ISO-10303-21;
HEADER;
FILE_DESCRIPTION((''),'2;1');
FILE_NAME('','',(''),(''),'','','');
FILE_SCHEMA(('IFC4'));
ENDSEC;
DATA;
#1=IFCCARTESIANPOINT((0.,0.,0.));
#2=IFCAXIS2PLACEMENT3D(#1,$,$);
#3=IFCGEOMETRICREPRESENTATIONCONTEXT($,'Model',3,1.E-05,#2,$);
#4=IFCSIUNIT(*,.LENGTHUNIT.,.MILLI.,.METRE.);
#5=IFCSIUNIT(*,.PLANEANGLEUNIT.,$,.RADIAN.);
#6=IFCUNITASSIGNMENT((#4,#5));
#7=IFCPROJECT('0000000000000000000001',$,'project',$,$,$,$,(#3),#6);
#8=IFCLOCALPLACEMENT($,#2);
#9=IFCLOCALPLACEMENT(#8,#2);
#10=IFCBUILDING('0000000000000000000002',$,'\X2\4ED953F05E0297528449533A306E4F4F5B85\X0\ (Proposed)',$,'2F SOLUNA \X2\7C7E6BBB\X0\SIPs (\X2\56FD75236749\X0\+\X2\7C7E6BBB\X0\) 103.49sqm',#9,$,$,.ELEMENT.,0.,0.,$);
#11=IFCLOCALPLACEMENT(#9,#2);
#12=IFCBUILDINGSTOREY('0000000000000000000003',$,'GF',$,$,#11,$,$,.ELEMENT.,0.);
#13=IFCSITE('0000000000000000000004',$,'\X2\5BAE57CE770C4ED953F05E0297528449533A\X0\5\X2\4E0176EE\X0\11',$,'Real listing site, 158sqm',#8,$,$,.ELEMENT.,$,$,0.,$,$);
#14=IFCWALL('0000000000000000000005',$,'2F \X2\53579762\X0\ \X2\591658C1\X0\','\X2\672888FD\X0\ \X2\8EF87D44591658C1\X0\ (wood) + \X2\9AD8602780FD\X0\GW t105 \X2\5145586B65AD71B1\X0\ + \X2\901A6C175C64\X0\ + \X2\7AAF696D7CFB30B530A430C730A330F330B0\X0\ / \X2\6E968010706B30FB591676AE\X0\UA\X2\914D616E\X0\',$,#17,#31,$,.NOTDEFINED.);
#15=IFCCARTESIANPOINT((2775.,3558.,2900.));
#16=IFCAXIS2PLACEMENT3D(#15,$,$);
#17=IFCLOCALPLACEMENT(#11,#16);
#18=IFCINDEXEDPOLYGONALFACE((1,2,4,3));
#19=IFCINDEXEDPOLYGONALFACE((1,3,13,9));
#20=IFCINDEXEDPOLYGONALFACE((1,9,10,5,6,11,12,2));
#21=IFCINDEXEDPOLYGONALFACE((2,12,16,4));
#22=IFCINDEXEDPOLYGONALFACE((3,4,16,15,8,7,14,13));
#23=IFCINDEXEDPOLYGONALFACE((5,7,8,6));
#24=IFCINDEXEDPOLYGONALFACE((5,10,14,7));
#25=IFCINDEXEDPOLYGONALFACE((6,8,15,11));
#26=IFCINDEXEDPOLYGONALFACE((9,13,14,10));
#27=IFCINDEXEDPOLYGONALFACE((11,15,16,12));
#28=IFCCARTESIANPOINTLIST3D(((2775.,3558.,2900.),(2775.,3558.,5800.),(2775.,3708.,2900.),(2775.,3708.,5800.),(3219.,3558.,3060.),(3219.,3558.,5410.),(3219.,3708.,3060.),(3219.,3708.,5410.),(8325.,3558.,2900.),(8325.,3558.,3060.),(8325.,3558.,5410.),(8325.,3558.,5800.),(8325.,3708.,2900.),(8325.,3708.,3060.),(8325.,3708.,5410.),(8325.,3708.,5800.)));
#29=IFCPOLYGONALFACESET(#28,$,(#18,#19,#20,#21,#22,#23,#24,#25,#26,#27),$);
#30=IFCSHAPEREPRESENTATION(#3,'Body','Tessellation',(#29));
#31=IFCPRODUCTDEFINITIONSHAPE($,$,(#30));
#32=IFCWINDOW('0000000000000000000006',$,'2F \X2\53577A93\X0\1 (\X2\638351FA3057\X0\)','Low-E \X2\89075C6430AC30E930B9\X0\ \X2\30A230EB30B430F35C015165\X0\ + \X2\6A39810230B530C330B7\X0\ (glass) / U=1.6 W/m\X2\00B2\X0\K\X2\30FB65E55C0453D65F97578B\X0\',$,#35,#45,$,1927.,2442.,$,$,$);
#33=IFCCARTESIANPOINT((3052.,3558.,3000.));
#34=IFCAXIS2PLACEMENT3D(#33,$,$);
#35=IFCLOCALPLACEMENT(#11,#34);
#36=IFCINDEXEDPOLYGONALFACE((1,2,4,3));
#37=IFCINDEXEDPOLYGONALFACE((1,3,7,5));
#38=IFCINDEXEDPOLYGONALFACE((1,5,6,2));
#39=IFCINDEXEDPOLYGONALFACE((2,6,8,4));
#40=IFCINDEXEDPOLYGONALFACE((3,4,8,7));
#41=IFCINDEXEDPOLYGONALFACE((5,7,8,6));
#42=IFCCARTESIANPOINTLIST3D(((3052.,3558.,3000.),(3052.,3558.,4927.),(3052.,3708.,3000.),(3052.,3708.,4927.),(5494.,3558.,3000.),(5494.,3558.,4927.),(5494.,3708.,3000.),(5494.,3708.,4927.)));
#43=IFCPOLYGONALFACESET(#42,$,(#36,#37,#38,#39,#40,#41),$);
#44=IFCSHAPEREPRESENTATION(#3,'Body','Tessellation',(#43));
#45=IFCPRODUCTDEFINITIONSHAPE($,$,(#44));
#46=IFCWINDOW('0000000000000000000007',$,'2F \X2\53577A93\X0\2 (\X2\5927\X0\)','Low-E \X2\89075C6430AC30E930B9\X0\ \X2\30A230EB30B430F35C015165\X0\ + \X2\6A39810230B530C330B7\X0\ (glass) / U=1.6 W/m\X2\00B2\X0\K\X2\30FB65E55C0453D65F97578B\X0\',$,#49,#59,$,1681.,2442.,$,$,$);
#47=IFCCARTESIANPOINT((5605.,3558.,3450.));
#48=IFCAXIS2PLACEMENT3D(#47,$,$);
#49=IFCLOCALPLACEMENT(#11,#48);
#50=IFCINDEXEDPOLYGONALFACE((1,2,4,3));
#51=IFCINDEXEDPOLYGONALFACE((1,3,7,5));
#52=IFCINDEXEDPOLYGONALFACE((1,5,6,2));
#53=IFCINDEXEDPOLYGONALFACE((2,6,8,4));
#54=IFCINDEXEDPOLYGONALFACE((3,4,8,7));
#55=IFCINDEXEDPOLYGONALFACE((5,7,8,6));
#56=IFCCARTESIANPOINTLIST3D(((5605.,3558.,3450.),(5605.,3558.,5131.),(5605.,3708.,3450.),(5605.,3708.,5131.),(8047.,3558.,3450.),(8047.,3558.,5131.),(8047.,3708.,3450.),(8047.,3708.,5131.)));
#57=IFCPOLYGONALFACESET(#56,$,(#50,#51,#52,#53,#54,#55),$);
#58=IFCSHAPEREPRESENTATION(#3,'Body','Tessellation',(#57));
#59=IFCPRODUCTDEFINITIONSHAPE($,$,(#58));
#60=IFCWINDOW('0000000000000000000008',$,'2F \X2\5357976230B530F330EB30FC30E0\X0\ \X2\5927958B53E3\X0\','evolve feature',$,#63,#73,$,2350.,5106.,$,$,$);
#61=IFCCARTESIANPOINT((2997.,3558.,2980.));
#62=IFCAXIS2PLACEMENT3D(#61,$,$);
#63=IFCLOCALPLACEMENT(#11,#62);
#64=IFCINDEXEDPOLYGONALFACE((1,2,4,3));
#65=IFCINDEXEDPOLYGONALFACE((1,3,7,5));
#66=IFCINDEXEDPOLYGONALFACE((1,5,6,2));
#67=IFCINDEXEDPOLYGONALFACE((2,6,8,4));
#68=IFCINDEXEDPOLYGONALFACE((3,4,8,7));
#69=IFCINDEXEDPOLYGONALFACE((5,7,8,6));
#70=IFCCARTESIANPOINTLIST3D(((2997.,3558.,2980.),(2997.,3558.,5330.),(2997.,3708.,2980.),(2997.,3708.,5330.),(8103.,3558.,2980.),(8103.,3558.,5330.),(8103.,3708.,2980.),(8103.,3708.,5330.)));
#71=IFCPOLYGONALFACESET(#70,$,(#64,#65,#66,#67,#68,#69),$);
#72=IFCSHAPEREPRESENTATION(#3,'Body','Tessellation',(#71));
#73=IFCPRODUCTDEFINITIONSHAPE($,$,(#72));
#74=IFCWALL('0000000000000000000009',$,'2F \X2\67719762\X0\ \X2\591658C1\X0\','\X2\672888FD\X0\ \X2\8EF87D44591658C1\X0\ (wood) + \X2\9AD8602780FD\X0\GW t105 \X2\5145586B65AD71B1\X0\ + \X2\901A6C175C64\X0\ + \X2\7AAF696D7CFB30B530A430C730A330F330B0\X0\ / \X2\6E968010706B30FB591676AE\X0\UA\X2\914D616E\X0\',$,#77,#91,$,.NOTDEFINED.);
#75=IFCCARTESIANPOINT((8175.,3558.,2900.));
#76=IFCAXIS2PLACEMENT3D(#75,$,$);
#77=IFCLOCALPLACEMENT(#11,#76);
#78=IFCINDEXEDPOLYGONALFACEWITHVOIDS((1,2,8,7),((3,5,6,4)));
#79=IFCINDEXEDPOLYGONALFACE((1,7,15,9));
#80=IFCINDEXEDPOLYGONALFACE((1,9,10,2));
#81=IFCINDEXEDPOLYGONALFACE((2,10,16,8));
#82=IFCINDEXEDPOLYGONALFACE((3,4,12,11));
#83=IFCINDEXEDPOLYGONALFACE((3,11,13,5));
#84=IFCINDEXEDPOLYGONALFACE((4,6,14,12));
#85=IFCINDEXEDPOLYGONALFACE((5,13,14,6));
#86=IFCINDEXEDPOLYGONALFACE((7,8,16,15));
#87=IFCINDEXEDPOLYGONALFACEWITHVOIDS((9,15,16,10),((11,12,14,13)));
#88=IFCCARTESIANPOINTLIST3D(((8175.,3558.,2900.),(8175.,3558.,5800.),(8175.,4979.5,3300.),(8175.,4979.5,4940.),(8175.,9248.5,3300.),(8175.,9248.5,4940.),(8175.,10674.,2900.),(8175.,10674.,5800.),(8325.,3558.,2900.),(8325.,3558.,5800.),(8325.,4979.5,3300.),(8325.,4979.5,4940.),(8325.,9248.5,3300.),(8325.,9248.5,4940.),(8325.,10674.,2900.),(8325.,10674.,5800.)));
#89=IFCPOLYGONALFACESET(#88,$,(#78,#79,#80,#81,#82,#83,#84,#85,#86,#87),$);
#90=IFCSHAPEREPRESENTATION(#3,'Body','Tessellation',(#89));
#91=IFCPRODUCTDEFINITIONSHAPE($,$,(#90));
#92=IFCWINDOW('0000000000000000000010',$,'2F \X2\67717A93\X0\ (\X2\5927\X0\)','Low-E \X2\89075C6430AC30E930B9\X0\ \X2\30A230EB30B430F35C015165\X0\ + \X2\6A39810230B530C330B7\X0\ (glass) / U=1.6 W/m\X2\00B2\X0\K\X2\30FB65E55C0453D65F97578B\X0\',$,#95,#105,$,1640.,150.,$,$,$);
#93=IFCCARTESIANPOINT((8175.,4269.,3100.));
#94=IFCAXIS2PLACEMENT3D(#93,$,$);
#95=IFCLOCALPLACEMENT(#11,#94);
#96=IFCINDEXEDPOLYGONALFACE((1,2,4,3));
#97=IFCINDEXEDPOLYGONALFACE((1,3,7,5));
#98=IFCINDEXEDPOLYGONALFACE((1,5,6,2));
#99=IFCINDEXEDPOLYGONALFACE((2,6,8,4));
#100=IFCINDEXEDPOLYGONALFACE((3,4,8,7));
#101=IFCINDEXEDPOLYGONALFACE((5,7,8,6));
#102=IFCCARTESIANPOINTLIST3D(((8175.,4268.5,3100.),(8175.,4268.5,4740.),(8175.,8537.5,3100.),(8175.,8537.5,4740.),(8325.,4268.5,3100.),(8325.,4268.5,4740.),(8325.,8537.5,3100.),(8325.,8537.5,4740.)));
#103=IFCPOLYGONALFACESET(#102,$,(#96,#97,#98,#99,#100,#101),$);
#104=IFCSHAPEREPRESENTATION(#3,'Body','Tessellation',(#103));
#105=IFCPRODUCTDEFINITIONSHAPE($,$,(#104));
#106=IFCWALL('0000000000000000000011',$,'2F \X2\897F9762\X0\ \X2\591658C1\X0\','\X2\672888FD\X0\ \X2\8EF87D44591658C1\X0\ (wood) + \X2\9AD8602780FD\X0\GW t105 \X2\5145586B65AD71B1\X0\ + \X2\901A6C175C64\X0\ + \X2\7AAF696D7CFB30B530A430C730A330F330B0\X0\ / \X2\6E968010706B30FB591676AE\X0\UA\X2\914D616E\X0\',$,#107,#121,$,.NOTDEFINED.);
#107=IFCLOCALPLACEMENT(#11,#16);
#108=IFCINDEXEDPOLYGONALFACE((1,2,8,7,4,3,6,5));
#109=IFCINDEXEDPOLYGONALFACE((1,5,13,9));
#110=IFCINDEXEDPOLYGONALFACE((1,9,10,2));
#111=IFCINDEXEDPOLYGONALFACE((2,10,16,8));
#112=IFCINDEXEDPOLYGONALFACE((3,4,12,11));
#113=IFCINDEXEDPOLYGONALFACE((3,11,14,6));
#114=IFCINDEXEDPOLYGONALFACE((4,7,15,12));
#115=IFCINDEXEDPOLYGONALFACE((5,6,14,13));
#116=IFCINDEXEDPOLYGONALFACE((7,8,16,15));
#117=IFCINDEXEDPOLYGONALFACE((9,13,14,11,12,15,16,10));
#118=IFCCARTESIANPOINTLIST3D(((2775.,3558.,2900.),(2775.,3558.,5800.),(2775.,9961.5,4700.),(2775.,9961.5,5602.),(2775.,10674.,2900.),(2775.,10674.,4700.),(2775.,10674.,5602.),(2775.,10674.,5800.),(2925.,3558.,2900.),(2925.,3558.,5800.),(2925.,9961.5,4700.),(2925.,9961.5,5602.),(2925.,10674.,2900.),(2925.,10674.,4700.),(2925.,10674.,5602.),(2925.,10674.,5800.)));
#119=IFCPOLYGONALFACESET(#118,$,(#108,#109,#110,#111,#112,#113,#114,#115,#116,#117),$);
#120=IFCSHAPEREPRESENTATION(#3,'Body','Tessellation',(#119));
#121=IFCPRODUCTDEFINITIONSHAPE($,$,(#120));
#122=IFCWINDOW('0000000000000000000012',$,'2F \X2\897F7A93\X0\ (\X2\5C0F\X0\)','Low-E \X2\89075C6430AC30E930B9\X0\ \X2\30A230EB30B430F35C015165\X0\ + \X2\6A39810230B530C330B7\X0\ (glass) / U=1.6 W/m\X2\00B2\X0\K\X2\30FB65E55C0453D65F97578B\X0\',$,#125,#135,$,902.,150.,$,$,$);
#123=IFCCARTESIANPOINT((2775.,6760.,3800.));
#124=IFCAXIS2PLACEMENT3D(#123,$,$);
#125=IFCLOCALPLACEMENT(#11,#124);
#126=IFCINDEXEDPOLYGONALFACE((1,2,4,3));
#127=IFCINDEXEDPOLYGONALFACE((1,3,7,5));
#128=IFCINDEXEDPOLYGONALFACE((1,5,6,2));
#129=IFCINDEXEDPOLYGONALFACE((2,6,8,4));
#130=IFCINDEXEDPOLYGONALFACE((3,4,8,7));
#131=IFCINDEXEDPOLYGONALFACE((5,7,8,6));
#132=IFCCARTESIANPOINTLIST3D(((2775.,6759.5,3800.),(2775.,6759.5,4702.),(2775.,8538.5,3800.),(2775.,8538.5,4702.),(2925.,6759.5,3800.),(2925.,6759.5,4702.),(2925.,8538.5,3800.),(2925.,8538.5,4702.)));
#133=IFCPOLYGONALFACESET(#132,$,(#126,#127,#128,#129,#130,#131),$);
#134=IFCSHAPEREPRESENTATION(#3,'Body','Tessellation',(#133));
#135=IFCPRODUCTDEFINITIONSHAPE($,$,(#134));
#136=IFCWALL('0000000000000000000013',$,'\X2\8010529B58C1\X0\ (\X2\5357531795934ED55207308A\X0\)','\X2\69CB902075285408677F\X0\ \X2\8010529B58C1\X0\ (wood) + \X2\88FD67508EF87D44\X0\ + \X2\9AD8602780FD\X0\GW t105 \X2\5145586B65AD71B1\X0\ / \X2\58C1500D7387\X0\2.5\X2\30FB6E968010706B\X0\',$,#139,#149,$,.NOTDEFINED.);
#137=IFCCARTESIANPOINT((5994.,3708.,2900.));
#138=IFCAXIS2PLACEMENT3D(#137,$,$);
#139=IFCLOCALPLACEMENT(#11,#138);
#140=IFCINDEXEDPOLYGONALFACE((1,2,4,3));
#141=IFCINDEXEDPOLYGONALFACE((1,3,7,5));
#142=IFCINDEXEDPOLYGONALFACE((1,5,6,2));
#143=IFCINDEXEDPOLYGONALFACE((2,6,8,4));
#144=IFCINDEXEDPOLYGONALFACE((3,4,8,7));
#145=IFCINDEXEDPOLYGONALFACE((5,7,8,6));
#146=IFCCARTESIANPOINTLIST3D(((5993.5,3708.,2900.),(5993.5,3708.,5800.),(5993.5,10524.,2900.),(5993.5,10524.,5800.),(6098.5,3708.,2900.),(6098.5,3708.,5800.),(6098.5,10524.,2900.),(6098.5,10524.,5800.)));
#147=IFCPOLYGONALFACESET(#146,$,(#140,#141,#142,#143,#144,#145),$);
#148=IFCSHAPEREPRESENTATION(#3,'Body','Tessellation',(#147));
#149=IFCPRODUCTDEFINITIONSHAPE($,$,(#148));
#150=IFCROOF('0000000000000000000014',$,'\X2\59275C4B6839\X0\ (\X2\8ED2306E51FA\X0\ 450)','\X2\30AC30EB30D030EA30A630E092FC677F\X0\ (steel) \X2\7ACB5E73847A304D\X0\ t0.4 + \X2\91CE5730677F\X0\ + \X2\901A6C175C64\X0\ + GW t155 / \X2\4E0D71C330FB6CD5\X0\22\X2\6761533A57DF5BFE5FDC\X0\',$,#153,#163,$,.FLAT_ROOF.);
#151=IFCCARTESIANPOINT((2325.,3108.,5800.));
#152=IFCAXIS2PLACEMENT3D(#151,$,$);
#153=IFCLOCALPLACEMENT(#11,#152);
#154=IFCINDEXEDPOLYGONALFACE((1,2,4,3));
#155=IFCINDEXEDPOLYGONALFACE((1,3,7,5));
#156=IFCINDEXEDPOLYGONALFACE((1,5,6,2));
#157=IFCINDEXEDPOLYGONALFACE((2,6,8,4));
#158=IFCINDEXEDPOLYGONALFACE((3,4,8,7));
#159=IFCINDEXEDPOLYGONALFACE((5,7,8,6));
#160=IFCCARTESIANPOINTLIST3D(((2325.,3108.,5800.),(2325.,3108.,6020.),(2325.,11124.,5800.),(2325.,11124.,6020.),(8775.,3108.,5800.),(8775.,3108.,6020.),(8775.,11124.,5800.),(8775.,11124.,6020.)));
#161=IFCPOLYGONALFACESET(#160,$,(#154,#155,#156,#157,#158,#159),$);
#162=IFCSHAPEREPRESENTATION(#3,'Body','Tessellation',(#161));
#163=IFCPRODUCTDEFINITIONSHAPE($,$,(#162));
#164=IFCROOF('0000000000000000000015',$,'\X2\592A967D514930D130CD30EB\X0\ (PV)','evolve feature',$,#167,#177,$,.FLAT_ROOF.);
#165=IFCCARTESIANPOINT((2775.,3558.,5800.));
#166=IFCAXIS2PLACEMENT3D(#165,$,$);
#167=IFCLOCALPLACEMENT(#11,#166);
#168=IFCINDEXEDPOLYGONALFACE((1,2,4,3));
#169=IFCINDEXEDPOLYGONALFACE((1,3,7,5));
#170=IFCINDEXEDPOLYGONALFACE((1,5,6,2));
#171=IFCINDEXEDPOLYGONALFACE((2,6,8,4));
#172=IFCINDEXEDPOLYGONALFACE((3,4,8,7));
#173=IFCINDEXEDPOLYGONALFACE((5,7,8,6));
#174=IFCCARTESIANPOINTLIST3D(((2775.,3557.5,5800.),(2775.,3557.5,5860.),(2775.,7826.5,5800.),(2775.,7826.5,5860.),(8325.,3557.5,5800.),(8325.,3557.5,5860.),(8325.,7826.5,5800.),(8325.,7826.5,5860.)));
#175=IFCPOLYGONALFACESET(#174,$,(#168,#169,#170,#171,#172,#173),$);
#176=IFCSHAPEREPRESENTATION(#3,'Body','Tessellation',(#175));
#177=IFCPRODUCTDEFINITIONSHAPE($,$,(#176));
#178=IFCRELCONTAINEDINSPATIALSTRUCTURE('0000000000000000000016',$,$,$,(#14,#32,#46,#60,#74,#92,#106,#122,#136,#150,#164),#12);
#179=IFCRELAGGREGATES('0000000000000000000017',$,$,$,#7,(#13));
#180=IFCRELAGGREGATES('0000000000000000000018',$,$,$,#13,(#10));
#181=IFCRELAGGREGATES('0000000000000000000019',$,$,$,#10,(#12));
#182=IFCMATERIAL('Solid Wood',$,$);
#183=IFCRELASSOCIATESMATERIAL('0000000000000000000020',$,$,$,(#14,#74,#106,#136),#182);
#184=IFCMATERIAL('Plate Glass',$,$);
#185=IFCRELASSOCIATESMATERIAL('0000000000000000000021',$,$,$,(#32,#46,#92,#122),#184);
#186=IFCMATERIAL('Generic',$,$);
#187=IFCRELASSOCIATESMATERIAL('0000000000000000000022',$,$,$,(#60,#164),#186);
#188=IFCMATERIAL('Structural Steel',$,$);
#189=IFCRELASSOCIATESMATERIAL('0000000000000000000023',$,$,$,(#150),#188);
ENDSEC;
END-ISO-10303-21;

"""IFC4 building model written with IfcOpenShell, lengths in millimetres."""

from ifc_helpers import new_model, si_unit, frame, frame_2d, origin, place, context, project, spatial, rectangle, extrude, material, element, fill, save


model = new_model("IFC4")

# Units and contexts
model_context = context("Model", 3, precision=1e-05, world=origin())
ifc_project = project(units=[si_unit("LENGTHUNIT", "METRE", prefix="MILLI"), si_unit("PLANEANGLEUNIT", "RADIAN")], contexts=[model_context])

# Site, building, storey
site_placement = place(None, origin())
site = spatial("IfcSite", under=ifc_project, at=site_placement, Name="宮城県仙台市青葉区5丁目11", ObjectType="Real listing site, 158sqm", CompositionType="ELEMENT", RefElevation=0.0)
building_placement = place(site_placement, origin())
building = spatial("IfcBuilding", under=site, at=building_placement, Name="仙台市青葉区の住宅 (Proposed)", ObjectType="2F SOLUNA 籾殻SIPs (国産杉+籾殻) 103.49sqm", CompositionType="ELEMENT", ElevationOfRefHeight=0.0, ElevationOfTerrain=0.0)
storey_placement = place(building_placement, origin())
storey = spatial("IfcBuildingStorey", under=building, at=storey_placement, Name="GF", CompositionType="ELEMENT", Elevation=0.0)

# Shared definitions
ifc_material_1 = material(Name="Solid Wood")

# Wall, openings, windows
wall_1_placement = place(storey_placement, frame((2775.0, 3558.0, 2900.0)))
wall_1 = element("IfcWall", 1, at=wall_1_placement, inside=storey, material=ifc_material_1, Name="2F 南面 外壁", Description="木製 軸組外壁 (wood) + 高性能GW t105 充填断熱 + 通気層 + 窯業系サイディング / 準耐火・外皮UA配慮", PredefinedType="NOTDEFINED", context=model_context, shape_type="SweptSolid", body=[
    extrude(rectangle(XDim=5550.0, YDim=150.0, at=frame_2d((2775.0, 75.0))), frame((2775.0, 3558.0, 2900.0)), (0.0, 0.0, 1.0), 2900.0),
])
opening_1_placement = place(storey_placement, frame((3052.0, 3558.0, 3000.0)))
opening_1 = element("IfcOpeningElement", 2, at=opening_1_placement, cuts=wall_1, PredefinedType="NOTDEFINED", context=model_context, shape_type="SweptSolid", body=[
    extrude(rectangle(XDim=2442.0, YDim=150.0, at=frame_2d((1221.0, 75.0))), frame((3052.0, 3558.0, 3000.0)), (0.0, 0.0, 1.0), 1927.0),
])
opening_2_placement = place(storey_placement, frame((5605.0, 3558.0, 3450.0)))
opening_2 = element("IfcOpeningElement", 3, at=opening_2_placement, cuts=wall_1, PredefinedType="NOTDEFINED", context=model_context, shape_type="SweptSolid", body=[
    extrude(rectangle(XDim=2442.0, YDim=150.0, at=frame_2d((1221.0, 75.0))), frame((5605.0, 3558.0, 3450.0)), (0.0, 0.0, 1.0), 1681.0),
])
opening_3_placement = place(storey_placement, frame((2997.0, 3558.0, 2980.0)))
opening_3 = element("IfcOpeningElement", 4, at=opening_3_placement, cuts=wall_1, PredefinedType="NOTDEFINED", context=model_context, shape_type="SweptSolid", body=[
    extrude(rectangle(XDim=5106.0, YDim=150.0, at=frame_2d((2553.0, 75.0))), frame((2997.0, 3558.0, 2980.0)), (0.0, 0.0, 1.0), 2350.0),
])
ifc_material_2 = material(Name="Plate Glass")
window_1_placement = place(storey_placement, frame((3052.0, 3558.0, 3000.0)))
window_1 = element("IfcWindow", 5, at=window_1_placement, inside=storey, material=ifc_material_2, Name="2F 南窓1 (掃出し)", Description="Low-E 複層ガラス アルゴン封入 + 樹脂サッシ (glass) / U=1.6 W/m²K・日射取得型", OverallHeight=1927.0, OverallWidth=2442.0, context=model_context, shape_type="SweptSolid", body=[
    extrude(rectangle(XDim=2442.0, YDim=150.0, at=frame_2d((1221.0, 75.0))), frame((3052.0, 3558.0, 3000.0)), (0.0, 0.0, 1.0), 1927.0),
])
fill(opening_1, window_1)
window_2_placement = place(storey_placement, frame((5605.0, 3558.0, 3450.0)))
window_2 = element("IfcWindow", 6, at=window_2_placement, inside=storey, material=ifc_material_2, Name="2F 南窓2 (大)", Description="Low-E 複層ガラス アルゴン封入 + 樹脂サッシ (glass) / U=1.6 W/m²K・日射取得型", OverallHeight=1681.0, OverallWidth=2442.0, context=model_context, shape_type="SweptSolid", body=[
    extrude(rectangle(XDim=2442.0, YDim=150.0, at=frame_2d((1221.0, 75.0))), frame((5605.0, 3558.0, 3450.0)), (0.0, 0.0, 1.0), 1681.0),
])
fill(opening_2, window_2)
ifc_material_3 = material(Name="Generic")
window_3_placement = place(storey_placement, frame((2997.0, 3558.0, 2980.0)))
window_3 = element("IfcWindow", 7, at=window_3_placement, inside=storey, material=ifc_material_3, Name="2F 南面サンルーム 大開口", Description="evolve feature", OverallHeight=2350.0, OverallWidth=5106.0, context=model_context, shape_type="SweptSolid", body=[
    extrude(rectangle(XDim=5106.0, YDim=150.0, at=frame_2d((2553.0, 75.0))), frame((2997.0, 3558.0, 2980.0)), (0.0, 0.0, 1.0), 2350.0),
])
fill(opening_3, window_3)

# Walls, openings, windows
wall_2_placement = place(storey_placement, frame((8175.0, 3558.0, 2900.0)))
wall_2 = element("IfcWall", 8, at=wall_2_placement, inside=storey, material=ifc_material_1, Name="2F 東面 外壁", Description="木製 軸組外壁 (wood) + 高性能GW t105 充填断熱 + 通気層 + 窯業系サイディング / 準耐火・外皮UA配慮", PredefinedType="NOTDEFINED", context=model_context, shape_type="SweptSolid", body=[
    extrude(rectangle(XDim=150.0, YDim=7116.0, at=frame_2d((75.0, 3558.0))), frame((8175.0, 3558.0, 2900.0)), (0.0, 0.0, 1.0), 2900.0),
])
opening_4_placement = place(storey_placement, frame((8175.0, 4269.0, 3100.0)))
opening_4 = element("IfcOpeningElement", 9, at=opening_4_placement, cuts=wall_2, PredefinedType="NOTDEFINED", context=model_context, shape_type="SweptSolid", body=[
    extrude(rectangle(XDim=150.0, YDim=4269.0, at=frame_2d((75.0, 2134.0))), frame((8175.0, 4269.0, 3100.0)), (0.0, 0.0, 1.0), 1640.0),
])
window_4_placement = place(storey_placement, frame((8175.0, 4269.0, 3100.0)))
window_4 = element("IfcWindow", 10, at=window_4_placement, inside=storey, material=ifc_material_2, Name="2F 東窓 (大)", Description="Low-E 複層ガラス アルゴン封入 + 樹脂サッシ (glass) / U=1.6 W/m²K・日射取得型", OverallHeight=1640.0, OverallWidth=150.0, context=model_context, shape_type="SweptSolid", body=[
    extrude(rectangle(XDim=150.0, YDim=4269.0, at=frame_2d((75.0, 2134.0))), frame((8175.0, 4269.0, 3100.0)), (0.0, 0.0, 1.0), 1640.0),
])
fill(opening_4, window_4)
wall_3_placement = place(storey_placement, frame((2775.0, 3558.0, 2900.0)))
wall_3 = element("IfcWall", 11, at=wall_3_placement, inside=storey, material=ifc_material_1, Name="2F 西面 外壁", Description="木製 軸組外壁 (wood) + 高性能GW t105 充填断熱 + 通気層 + 窯業系サイディング / 準耐火・外皮UA配慮", PredefinedType="NOTDEFINED", context=model_context, shape_type="SweptSolid", body=[
    extrude(rectangle(XDim=150.0, YDim=7116.0, at=frame_2d((75.0, 3558.0))), frame((2775.0, 3558.0, 2900.0)), (0.0, 0.0, 1.0), 2900.0),
])
opening_5_placement = place(storey_placement, frame((2775.0, 6760.0, 3800.0)))
opening_5 = element("IfcOpeningElement", 12, at=opening_5_placement, cuts=wall_3, PredefinedType="NOTDEFINED", context=model_context, shape_type="SweptSolid", body=[
    extrude(rectangle(XDim=150.0, YDim=1779.0, at=frame_2d((75.0, 889.0))), frame((2775.0, 6760.0, 3800.0)), (0.0, 0.0, 1.0), 902.0),
])
window_5_placement = place(storey_placement, frame((2775.0, 6760.0, 3800.0)))
window_5 = element("IfcWindow", 13, at=window_5_placement, inside=storey, material=ifc_material_2, Name="2F 西窓 (小)", Description="Low-E 複層ガラス アルゴン封入 + 樹脂サッシ (glass) / U=1.6 W/m²K・日射取得型", OverallHeight=902.0, OverallWidth=150.0, context=model_context, shape_type="SweptSolid", body=[
    extrude(rectangle(XDim=150.0, YDim=1779.0, at=frame_2d((75.0, 889.0))), frame((2775.0, 6760.0, 3800.0)), (0.0, 0.0, 1.0), 902.0),
])
fill(opening_5, window_5)

# Wall
wall_4_placement = place(storey_placement, frame((5994.0, 3708.0, 2900.0)))
element("IfcWall", 14, at=wall_4_placement, inside=storey, material=ifc_material_1, Name="耐力壁 (南北間仕切り)", Description="構造用合板 耐力壁 (wood) + 製材軸組 + 高性能GW t105 充填断熱 / 壁倍率2.5・準耐火", PredefinedType="NOTDEFINED", context=model_context, shape_type="SweptSolid", body=[
    extrude(rectangle(XDim=105.0, YDim=6816.0, at=frame_2d((52.0, 3408.0))), frame((5994.0, 3708.0, 2900.0)), (0.0, 0.0, 1.0), 2900.0),
])

# Roofs
ifc_material_4 = material(Name="Structural Steel")
roof_1_placement = place(storey_placement, frame((2325.0, 3108.0, 5800.0)))
element("IfcRoof", 15, at=roof_1_placement, inside=storey, material=ifc_material_4, Name="大屋根 (軒の出 450)", Description="ガルバリウム鋼板 (steel) 立平葺き t0.4 + 野地板 + 通気層 + GW t155 / 不燃・法22条区域対応", PredefinedType="FLAT_ROOF", context=model_context, shape_type="SweptSolid", body=[
    extrude(rectangle(XDim=6450.0, YDim=8016.0, at=frame_2d((3225.0, 4008.0))), frame((2325.0, 3108.0, 5800.0)), (0.0, 0.0, 1.0), 220.0),
])
roof_2_placement = place(storey_placement, frame((2775.0, 3558.0, 5800.0)))
element("IfcRoof", 16, at=roof_2_placement, inside=storey, material=ifc_material_3, Name="太陽光パネル (PV)", Description="evolve feature", PredefinedType="FLAT_ROOF", context=model_context, shape_type="SweptSolid", body=[
    extrude(rectangle(XDim=5550.0, YDim=4269.0, at=frame_2d((2775.0, 2134.0))), frame((2775.0, 3558.0, 5800.0)), (0.0, 0.0, 1.0), 60.0),
])

save(model, "model.ifc")
